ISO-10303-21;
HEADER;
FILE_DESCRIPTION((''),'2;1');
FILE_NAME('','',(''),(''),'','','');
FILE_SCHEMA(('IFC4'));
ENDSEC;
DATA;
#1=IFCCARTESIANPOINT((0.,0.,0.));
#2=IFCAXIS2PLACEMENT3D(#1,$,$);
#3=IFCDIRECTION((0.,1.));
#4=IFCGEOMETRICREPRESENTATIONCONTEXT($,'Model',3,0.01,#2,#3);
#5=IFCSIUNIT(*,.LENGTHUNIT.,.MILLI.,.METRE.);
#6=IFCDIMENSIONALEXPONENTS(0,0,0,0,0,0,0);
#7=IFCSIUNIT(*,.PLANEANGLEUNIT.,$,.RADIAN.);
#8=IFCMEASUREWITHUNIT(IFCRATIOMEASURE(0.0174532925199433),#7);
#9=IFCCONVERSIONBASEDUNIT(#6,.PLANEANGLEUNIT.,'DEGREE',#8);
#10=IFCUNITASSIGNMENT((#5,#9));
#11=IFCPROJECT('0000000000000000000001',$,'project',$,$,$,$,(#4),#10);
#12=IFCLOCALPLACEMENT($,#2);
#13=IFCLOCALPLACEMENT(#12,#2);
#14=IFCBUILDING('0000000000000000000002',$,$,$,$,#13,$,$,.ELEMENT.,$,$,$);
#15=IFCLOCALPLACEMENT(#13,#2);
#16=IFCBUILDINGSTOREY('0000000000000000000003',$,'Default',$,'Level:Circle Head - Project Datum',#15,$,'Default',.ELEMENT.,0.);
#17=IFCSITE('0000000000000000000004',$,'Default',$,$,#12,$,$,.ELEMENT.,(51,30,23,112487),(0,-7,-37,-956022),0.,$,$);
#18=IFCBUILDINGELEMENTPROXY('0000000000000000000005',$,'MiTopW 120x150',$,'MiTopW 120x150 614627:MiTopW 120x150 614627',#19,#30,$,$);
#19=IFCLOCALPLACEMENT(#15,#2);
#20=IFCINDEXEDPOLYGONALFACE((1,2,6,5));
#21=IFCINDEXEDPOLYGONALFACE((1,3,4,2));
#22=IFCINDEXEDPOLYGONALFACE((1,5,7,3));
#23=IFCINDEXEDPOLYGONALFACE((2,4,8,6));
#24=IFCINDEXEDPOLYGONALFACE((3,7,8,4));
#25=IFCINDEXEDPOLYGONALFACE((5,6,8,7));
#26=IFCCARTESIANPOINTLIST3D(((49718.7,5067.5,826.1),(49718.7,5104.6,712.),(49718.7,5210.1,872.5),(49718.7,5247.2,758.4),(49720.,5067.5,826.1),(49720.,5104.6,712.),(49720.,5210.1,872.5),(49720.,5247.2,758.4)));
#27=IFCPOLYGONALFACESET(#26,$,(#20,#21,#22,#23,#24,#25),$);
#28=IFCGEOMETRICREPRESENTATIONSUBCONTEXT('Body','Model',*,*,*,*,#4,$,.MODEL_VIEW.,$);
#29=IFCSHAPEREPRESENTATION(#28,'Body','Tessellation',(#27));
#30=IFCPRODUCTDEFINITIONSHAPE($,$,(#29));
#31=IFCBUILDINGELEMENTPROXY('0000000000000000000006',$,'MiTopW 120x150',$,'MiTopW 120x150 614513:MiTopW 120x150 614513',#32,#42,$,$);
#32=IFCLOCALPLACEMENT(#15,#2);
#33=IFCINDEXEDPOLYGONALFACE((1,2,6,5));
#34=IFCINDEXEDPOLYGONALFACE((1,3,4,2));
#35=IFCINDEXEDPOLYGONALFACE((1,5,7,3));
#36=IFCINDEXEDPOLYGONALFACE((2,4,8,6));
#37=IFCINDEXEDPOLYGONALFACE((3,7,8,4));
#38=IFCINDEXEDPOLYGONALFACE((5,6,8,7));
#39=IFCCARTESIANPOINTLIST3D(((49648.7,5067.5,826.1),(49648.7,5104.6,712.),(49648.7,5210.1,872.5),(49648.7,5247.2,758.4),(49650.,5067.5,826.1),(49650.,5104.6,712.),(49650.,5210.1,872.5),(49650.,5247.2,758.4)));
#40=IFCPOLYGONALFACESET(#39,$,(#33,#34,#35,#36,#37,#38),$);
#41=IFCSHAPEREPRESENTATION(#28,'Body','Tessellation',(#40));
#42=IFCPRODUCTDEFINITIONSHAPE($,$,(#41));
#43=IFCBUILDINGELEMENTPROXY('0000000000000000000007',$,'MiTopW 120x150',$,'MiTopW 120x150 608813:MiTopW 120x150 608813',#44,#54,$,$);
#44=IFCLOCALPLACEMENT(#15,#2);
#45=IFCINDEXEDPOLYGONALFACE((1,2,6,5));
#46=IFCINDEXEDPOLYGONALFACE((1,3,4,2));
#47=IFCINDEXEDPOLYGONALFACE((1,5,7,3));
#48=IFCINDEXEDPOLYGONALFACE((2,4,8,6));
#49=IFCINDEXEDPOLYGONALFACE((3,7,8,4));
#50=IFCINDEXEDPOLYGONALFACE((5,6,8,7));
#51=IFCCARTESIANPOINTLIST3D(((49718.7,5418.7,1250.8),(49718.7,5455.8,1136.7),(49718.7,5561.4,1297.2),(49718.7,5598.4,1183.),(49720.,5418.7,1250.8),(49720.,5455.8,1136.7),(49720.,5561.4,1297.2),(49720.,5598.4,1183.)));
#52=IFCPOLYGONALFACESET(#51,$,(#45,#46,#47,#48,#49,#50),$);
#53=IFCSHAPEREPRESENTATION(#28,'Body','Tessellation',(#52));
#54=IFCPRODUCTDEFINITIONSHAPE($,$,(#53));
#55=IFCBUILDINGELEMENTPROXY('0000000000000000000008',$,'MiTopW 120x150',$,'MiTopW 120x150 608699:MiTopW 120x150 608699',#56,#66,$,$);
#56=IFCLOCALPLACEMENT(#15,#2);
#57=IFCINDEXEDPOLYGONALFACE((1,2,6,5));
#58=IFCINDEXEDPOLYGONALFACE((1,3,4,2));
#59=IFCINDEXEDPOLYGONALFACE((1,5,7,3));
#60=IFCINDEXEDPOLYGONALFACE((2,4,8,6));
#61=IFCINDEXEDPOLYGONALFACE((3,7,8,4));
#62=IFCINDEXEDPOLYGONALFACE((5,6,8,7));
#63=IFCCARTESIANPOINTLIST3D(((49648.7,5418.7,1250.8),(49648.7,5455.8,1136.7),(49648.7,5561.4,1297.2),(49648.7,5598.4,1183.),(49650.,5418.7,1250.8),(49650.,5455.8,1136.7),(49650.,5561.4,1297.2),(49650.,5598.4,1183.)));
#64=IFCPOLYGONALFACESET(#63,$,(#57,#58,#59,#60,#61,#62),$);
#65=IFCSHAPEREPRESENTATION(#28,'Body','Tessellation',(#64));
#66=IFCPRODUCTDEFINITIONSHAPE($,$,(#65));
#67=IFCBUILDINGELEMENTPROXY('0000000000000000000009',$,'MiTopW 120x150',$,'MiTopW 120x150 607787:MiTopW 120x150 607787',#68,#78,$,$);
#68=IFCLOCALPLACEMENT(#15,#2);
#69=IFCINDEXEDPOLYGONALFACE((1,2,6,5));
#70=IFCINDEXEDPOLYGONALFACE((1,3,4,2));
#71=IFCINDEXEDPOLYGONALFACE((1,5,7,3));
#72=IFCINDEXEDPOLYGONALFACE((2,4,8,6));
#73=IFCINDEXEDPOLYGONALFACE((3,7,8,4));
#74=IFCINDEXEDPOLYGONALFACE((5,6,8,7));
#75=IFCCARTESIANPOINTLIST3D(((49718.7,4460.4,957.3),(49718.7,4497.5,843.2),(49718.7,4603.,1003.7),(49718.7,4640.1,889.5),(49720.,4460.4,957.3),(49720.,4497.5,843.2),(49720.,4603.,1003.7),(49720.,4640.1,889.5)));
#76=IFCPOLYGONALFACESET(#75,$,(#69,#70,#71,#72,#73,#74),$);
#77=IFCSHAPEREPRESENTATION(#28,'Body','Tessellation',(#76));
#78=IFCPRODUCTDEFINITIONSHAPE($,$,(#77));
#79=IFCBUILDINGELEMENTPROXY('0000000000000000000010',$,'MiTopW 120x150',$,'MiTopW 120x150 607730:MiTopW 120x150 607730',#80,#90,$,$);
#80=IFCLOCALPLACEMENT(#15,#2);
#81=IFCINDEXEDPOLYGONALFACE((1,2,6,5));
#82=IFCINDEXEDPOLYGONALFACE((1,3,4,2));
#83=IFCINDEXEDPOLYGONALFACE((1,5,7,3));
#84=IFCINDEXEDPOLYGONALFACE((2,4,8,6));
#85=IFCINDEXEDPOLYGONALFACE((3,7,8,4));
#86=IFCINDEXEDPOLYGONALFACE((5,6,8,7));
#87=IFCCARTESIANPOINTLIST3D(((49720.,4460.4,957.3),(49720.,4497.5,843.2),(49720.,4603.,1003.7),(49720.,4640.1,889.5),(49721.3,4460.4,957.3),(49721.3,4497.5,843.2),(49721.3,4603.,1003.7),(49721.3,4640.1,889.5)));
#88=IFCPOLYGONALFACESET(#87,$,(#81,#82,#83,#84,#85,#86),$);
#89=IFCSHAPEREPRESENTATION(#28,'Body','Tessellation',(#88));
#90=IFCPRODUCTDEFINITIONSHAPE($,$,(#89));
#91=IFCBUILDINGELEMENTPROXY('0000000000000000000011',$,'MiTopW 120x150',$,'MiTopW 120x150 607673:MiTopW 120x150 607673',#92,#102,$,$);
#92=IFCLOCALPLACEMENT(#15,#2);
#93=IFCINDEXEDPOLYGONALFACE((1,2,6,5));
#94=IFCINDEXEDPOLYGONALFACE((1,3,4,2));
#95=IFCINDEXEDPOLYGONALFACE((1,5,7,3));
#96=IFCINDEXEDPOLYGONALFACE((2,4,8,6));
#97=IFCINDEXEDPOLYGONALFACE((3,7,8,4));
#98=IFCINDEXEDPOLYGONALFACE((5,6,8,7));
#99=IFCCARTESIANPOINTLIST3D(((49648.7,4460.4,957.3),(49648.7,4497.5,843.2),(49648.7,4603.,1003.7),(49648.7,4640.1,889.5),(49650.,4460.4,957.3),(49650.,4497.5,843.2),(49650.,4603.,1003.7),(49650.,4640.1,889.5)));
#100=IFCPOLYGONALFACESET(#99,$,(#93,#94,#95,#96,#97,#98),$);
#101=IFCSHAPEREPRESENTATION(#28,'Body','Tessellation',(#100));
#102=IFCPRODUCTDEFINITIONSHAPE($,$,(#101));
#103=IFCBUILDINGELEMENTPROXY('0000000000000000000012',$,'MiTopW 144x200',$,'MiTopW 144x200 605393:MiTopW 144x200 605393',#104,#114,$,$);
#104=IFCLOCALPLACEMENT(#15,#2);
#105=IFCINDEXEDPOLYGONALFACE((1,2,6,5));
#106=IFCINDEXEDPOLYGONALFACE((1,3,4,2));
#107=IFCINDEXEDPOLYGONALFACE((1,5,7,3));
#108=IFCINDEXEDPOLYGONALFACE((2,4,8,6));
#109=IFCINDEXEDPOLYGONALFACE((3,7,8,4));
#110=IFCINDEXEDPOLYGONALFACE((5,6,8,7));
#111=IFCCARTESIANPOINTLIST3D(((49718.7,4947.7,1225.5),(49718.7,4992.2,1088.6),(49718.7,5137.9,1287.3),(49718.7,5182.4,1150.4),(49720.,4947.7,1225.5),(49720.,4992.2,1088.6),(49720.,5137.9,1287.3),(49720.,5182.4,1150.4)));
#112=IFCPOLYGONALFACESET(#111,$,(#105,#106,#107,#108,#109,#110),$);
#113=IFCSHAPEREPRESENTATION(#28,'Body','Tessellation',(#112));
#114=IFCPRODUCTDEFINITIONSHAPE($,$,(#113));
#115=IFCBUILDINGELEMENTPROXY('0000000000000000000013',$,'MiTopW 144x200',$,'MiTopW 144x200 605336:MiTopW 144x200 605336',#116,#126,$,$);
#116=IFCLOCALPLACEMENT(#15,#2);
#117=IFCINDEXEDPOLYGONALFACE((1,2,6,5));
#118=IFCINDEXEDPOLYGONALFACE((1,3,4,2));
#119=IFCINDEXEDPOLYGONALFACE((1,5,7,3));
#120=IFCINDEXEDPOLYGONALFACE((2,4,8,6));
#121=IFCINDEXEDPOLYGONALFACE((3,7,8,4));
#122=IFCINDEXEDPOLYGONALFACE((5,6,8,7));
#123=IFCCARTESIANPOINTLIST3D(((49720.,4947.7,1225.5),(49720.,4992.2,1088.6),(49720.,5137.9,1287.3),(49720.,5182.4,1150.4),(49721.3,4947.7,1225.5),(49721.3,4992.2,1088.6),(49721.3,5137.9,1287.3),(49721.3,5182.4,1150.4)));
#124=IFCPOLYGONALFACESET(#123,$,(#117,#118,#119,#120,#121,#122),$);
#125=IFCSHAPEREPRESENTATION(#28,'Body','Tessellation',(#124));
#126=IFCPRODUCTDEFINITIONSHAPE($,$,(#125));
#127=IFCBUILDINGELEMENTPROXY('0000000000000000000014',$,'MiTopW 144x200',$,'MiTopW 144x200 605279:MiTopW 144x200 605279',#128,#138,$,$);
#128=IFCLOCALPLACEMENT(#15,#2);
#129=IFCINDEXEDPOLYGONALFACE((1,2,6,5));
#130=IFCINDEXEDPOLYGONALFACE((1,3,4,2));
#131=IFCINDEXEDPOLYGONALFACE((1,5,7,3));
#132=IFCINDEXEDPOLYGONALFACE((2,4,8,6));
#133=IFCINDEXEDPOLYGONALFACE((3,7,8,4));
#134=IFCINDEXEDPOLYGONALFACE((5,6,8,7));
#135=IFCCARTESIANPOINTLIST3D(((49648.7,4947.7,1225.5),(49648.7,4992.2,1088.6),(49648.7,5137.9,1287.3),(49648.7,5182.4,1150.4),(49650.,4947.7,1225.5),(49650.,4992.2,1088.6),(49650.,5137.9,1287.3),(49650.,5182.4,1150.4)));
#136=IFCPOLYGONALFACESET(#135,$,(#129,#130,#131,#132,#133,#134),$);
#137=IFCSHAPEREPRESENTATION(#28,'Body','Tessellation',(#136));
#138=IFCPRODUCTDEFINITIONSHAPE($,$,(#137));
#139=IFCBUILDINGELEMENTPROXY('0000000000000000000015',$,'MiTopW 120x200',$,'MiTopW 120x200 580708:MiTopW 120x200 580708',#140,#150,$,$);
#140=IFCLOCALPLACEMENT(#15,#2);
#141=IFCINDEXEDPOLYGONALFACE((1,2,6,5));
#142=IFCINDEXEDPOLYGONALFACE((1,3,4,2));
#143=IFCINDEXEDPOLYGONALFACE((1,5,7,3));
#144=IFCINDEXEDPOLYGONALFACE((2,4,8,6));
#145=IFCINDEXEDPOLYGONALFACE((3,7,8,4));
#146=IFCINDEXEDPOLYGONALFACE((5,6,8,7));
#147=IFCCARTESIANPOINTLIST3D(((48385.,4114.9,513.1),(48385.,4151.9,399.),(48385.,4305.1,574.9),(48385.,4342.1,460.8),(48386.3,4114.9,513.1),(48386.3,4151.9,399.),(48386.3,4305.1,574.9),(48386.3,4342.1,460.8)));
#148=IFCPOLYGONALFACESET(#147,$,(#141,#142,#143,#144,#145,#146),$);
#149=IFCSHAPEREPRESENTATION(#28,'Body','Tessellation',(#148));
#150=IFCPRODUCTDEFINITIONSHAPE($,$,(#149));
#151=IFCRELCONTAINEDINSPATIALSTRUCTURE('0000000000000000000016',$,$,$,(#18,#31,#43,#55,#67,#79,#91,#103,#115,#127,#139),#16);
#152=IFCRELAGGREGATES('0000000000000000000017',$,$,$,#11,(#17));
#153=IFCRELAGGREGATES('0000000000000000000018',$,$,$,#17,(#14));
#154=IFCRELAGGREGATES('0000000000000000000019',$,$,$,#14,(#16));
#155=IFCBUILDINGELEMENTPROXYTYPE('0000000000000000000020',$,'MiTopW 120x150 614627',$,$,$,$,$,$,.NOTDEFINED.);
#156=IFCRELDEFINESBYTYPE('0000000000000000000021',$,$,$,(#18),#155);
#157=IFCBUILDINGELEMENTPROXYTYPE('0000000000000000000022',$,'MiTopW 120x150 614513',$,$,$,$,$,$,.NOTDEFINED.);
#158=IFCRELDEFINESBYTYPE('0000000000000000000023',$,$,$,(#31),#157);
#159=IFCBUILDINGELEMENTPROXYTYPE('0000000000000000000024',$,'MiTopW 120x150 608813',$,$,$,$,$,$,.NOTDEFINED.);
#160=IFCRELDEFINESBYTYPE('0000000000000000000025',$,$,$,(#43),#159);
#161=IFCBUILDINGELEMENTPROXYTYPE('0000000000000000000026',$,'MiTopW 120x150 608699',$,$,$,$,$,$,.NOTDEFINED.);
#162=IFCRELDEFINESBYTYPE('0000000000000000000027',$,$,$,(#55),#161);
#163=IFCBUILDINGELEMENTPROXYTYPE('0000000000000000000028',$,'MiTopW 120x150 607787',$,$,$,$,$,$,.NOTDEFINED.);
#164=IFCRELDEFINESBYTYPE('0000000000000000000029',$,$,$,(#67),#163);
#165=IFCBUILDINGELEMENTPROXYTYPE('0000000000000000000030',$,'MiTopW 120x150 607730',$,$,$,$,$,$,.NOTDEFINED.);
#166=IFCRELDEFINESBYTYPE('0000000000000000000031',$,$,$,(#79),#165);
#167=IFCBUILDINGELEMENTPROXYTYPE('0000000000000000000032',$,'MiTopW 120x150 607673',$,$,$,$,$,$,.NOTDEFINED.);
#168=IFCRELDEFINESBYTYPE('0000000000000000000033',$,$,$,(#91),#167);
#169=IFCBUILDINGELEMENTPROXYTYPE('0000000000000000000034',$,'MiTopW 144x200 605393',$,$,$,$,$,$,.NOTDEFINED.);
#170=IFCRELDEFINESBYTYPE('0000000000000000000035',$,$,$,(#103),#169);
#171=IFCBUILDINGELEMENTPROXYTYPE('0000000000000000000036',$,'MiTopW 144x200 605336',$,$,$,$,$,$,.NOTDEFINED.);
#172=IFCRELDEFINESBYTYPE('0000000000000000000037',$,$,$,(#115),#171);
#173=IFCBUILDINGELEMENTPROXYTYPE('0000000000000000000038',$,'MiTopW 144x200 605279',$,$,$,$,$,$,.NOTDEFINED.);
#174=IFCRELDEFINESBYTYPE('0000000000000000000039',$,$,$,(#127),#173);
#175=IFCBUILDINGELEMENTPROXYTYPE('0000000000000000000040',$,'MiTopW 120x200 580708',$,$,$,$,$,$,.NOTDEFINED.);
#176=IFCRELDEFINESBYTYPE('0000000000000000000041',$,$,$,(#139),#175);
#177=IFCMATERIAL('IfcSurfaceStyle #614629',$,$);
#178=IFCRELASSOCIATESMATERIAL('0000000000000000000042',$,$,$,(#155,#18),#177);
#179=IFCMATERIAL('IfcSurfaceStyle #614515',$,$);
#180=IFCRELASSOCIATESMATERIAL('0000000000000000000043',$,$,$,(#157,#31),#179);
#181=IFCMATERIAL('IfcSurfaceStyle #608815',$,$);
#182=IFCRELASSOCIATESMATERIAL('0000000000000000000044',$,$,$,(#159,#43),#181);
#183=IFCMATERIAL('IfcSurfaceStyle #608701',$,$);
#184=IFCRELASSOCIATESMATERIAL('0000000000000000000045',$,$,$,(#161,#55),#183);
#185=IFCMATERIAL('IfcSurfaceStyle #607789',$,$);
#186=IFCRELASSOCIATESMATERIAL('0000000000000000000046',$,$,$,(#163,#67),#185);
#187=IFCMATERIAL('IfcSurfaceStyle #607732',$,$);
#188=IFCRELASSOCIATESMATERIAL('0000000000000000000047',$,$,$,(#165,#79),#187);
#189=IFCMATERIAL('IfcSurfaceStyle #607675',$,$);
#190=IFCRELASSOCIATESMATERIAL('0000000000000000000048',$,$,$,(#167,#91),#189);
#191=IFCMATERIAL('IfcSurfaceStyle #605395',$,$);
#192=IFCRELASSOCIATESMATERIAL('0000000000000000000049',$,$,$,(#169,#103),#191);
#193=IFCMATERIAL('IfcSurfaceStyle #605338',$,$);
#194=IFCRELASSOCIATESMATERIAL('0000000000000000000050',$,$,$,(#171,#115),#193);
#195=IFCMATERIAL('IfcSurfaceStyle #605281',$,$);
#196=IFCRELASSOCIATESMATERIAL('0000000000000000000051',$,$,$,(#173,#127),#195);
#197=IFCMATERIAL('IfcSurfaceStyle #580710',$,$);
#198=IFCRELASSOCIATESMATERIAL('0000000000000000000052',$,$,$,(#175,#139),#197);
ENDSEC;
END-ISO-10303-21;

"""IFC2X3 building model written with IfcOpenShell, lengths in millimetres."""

from ifc_helpers import new_model, entity, si_unit, converted_unit, direction, frame, origin, place, context, subcontext, project, spatial, polyline, outline, extrude, source, transform, mapped, material, type_object, type_shapes, element, save


model = new_model("IFC2X3")

# Units and contexts
model_context = context("Model", 3, precision=0.01, world=origin(), true_north=direction((0.0, 1.0)))
body_context = subcontext(model_context, "Body", "Model", "MODEL_VIEW")
ifc_project = project(units=[si_unit("LENGTHUNIT", "METRE", prefix="MILLI"), converted_unit("PLANEANGLEUNIT", "DEGREE", entity("IfcRatioMeasure", 0.0174532925199433), si_unit("PLANEANGLEUNIT", "RADIAN"), dimensions=[0, 0, 0, 0, 0, 0, 0])], contexts=[model_context])

# Site, building, storey
site_placement = place(None, origin())
site = spatial("IfcSite", under=ifc_project, at=site_placement, Name="Default", CompositionType="ELEMENT", RefLatitude=(51, 30, 23, 112487), RefLongitude=(0, -7, -37, -956022), RefElevation=0.0)
building_placement = place(site_placement, origin())
building = spatial("IfcBuilding", under=site, at=building_placement, CompositionType="ELEMENT")
storey_placement = place(building_placement, origin())
storey = spatial("IfcBuildingStorey", under=building, at=storey_placement, Name="Default", ObjectType="Level:Circle Head - Project Datum", LongName="Default", CompositionType="ELEMENT", Elevation=0.0)

# Building element proxies
ifc_material_1 = material(Name="IfcSurfaceStyle #614629")
building_element_proxy_type_1 = type_object("IfcBuildingElementProxyType", Name="MiTopW 120x150 614627", PredefinedType="NOTDEFINED", material=ifc_material_1)
shared_shape_1 = source(origin(), body_context, "Body", "SweptSolid", [
    extrude(outline(polyline([(-75.0, -60.0), (75.0, -60.0), (75.0, 60.0), (-75.0, 60.0), (-75.0, -60.0)])), frame((75.0, 60.0, 0.0), z_axis=(0.0, 0.0, 1.0), x_axis=(-1.0, 0.0, 0.0)), (0.0, 0.0, 1.0), 1.3),
])
type_shapes(building_element_proxy_type_1, [shared_shape_1])
proxy_1_placement = place(building_placement, frame((49720.0, 5067.5, 826.1), z_axis=(-1.0, 0.0, 0.0), x_axis=(0.0, 0.951057, 0.309017)))
element("IfcBuildingElementProxy", 1, at=proxy_1_placement, inside=storey, type_object=building_element_proxy_type_1, material=ifc_material_1, Name="MiTopW 120x150", ObjectType="MiTopW 120x150 614627:MiTopW 120x150 614627", context=body_context, shape_type="MappedRepresentation", body=[
    mapped(shared_shape_1, transform((0.0, 0.0, 0.0), scale=1.0)),
])
ifc_material_2 = material(Name="IfcSurfaceStyle #614515")
building_element_proxy_type_2 = type_object("IfcBuildingElementProxyType", Name="MiTopW 120x150 614513", PredefinedType="NOTDEFINED", material=ifc_material_2)
shared_shape_2 = source(origin(), body_context, "Body", "SweptSolid", [
    extrude(outline(polyline([(-75.0, -60.0), (75.0, -60.0), (75.0, 60.0), (-75.0, 60.0), (-75.0, -60.0)])), frame((75.0, 60.0, 0.0), z_axis=(0.0, 0.0, 1.0), x_axis=(-1.0, 0.0, 0.0)), (0.0, 0.0, 1.0), 1.3),
])
type_shapes(building_element_proxy_type_2, [shared_shape_2])
proxy_2_placement = place(building_placement, frame((49650.0, 5067.5, 826.1), z_axis=(-1.0, 0.0, 0.0), x_axis=(0.0, 0.951057, 0.309017)))
element("IfcBuildingElementProxy", 2, at=proxy_2_placement, inside=storey, type_object=building_element_proxy_type_2, material=ifc_material_2, Name="MiTopW 120x150", ObjectType="MiTopW 120x150 614513:MiTopW 120x150 614513", context=body_context, shape_type="MappedRepresentation", body=[
    mapped(shared_shape_2, transform((0.0, 0.0, 0.0), scale=1.0)),
])
ifc_material_3 = material(Name="IfcSurfaceStyle #608815")
building_element_proxy_type_3 = type_object("IfcBuildingElementProxyType", Name="MiTopW 120x150 608813", PredefinedType="NOTDEFINED", material=ifc_material_3)
shared_shape_3 = source(origin(), body_context, "Body", "SweptSolid", [
    extrude(outline(polyline([(-75.0, -60.0), (75.0, -60.0), (75.0, 60.0), (-75.0, 60.0), (-75.0, -60.0)])), frame((75.0, 60.0, 0.0), z_axis=(0.0, 0.0, 1.0), x_axis=(-1.0, 0.0, 0.0)), (0.0, 0.0, 1.0), 1.3),
])
type_shapes(building_element_proxy_type_3, [shared_shape_3])
proxy_3_placement = place(building_placement, frame((49720.0, 5418.7, 1250.8), z_axis=(-1.0, 0.0, 0.0), x_axis=(0.0, 0.951057, 0.309017)))
element("IfcBuildingElementProxy", 3, at=proxy_3_placement, inside=storey, type_object=building_element_proxy_type_3, material=ifc_material_3, Name="MiTopW 120x150", ObjectType="MiTopW 120x150 608813:MiTopW 120x150 608813", context=body_context, shape_type="MappedRepresentation", body=[
    mapped(shared_shape_3, transform((0.0, 0.0, 0.0), scale=1.0)),
])
ifc_material_4 = material(Name="IfcSurfaceStyle #608701")
building_element_proxy_type_4 = type_object("IfcBuildingElementProxyType", Name="MiTopW 120x150 608699", PredefinedType="NOTDEFINED", material=ifc_material_4)
shared_shape_4 = source(origin(), body_context, "Body", "SweptSolid", [
    extrude(outline(polyline([(-75.0, -60.0), (75.0, -60.0), (75.0, 60.0), (-75.0, 60.0), (-75.0, -60.0)])), frame((75.0, 60.0, 0.0), z_axis=(0.0, 0.0, 1.0), x_axis=(-1.0, 0.0, 0.0)), (0.0, 0.0, 1.0), 1.3),
])
type_shapes(building_element_proxy_type_4, [shared_shape_4])
proxy_4_placement = place(building_placement, frame((49650.0, 5418.7, 1250.8), z_axis=(-1.0, 0.0, 0.0), x_axis=(0.0, 0.951057, 0.309017)))
element("IfcBuildingElementProxy", 4, at=proxy_4_placement, inside=storey, type_object=building_element_proxy_type_4, material=ifc_material_4, Name="MiTopW 120x150", ObjectType="MiTopW 120x150 608699:MiTopW 120x150 608699", context=body_context, shape_type="MappedRepresentation", body=[
    mapped(shared_shape_4, transform((0.0, 0.0, 0.0), scale=1.0)),
])
ifc_material_5 = material(Name="IfcSurfaceStyle #607789")
building_element_proxy_type_5 = type_object("IfcBuildingElementProxyType", Name="MiTopW 120x150 607787", PredefinedType="NOTDEFINED", material=ifc_material_5)
shared_shape_5 = source(origin(), body_context, "Body", "SweptSolid", [
    extrude(outline(polyline([(-75.0, -60.0), (75.0, -60.0), (75.0, 60.0), (-75.0, 60.0), (-75.0, -60.0)])), frame((75.0, 60.0, 0.0), z_axis=(0.0, 0.0, 1.0), x_axis=(-1.0, 0.0, 0.0)), (0.0, 0.0, 1.0), 1.3),
])
type_shapes(building_element_proxy_type_5, [shared_shape_5])
proxy_5_placement = place(building_placement, frame((49720.0, 4460.4, 957.3), z_axis=(-1.0, 0.0, 0.0), x_axis=(0.0, 0.951057, 0.309017)))
element("IfcBuildingElementProxy", 5, at=proxy_5_placement, inside=storey, type_object=building_element_proxy_type_5, material=ifc_material_5, Name="MiTopW 120x150", ObjectType="MiTopW 120x150 607787:MiTopW 120x150 607787", context=body_context, shape_type="MappedRepresentation", body=[
    mapped(shared_shape_5, transform((0.0, 0.0, 0.0), scale=1.0)),
])
ifc_material_6 = material(Name="IfcSurfaceStyle #607732")
building_element_proxy_type_6 = type_object("IfcBuildingElementProxyType", Name="MiTopW 120x150 607730", PredefinedType="NOTDEFINED", material=ifc_material_6)
shared_shape_6 = source(origin(), body_context, "Body", "SweptSolid", [
    extrude(outline(polyline([(-75.0, -60.0), (75.0, -60.0), (75.0, 60.0), (-75.0, 60.0), (-75.0, -60.0)])), frame((75.0, 60.0, 0.0), z_axis=(0.0, 0.0, 1.0), x_axis=(-1.0, 0.0, 0.0)), (0.0, 0.0, 1.0), 1.3),
])
type_shapes(building_element_proxy_type_6, [shared_shape_6])
proxy_6_placement = place(building_placement, frame((49721.3, 4460.4, 957.3), z_axis=(-1.0, 0.0, 0.0), x_axis=(0.0, 0.951057, 0.309017)))
element("IfcBuildingElementProxy", 6, at=proxy_6_placement, inside=storey, type_object=building_element_proxy_type_6, material=ifc_material_6, Name="MiTopW 120x150", ObjectType="MiTopW 120x150 607730:MiTopW 120x150 607730", context=body_context, shape_type="MappedRepresentation", body=[
    mapped(shared_shape_6, transform((0.0, 0.0, 0.0), scale=1.0)),
])
ifc_material_7 = material(Name="IfcSurfaceStyle #607675")
building_element_proxy_type_7 = type_object("IfcBuildingElementProxyType", Name="MiTopW 120x150 607673", PredefinedType="NOTDEFINED", material=ifc_material_7)
shared_shape_7 = source(origin(), body_context, "Body", "SweptSolid", [
    extrude(outline(polyline([(-75.0, -60.0), (75.0, -60.0), (75.0, 60.0), (-75.0, 60.0), (-75.0, -60.0)])), frame((75.0, 60.0, 0.0), z_axis=(0.0, 0.0, 1.0), x_axis=(-1.0, 0.0, 0.0)), (0.0, 0.0, 1.0), 1.3),
])
type_shapes(building_element_proxy_type_7, [shared_shape_7])
proxy_7_placement = place(building_placement, frame((49650.0, 4460.4, 957.3), z_axis=(-1.0, 0.0, 0.0), x_axis=(0.0, 0.951057, 0.309017)))
element("IfcBuildingElementProxy", 7, at=proxy_7_placement, inside=storey, type_object=building_element_proxy_type_7, material=ifc_material_7, Name="MiTopW 120x150", ObjectType="MiTopW 120x150 607673:MiTopW 120x150 607673", context=body_context, shape_type="MappedRepresentation", body=[
    mapped(shared_shape_7, transform((0.0, 0.0, 0.0), scale=1.0)),
])
ifc_material_8 = material(Name="IfcSurfaceStyle #605395")
building_element_proxy_type_8 = type_object("IfcBuildingElementProxyType", Name="MiTopW 144x200 605393", PredefinedType="NOTDEFINED", material=ifc_material_8)
shared_shape_8 = source(origin(), body_context, "Body", "SweptSolid", [
    extrude(outline(polyline([(-100.0, -72.0), (100.0, -72.0), (100.0, 72.0), (-100.0, 72.0), (-100.0, -72.0)])), frame((100.0, 72.0, 0.0), z_axis=(0.0, 0.0, 1.0), x_axis=(-1.0, 0.0, 0.0)), (0.0, 0.0, 1.0), 1.3),
])
type_shapes(building_element_proxy_type_8, [shared_shape_8])
proxy_8_placement = place(building_placement, frame((49720.0, 4947.7, 1225.5), z_axis=(-1.0, 0.0, 0.0), x_axis=(0.0, 0.951057, 0.309017)))
element("IfcBuildingElementProxy", 8, at=proxy_8_placement, inside=storey, type_object=building_element_proxy_type_8, material=ifc_material_8, Name="MiTopW 144x200", ObjectType="MiTopW 144x200 605393:MiTopW 144x200 605393", context=body_context, shape_type="MappedRepresentation", body=[
    mapped(shared_shape_8, transform((0.0, 0.0, 0.0), scale=1.0)),
])
ifc_material_9 = material(Name="IfcSurfaceStyle #605338")
building_element_proxy_type_9 = type_object("IfcBuildingElementProxyType", Name="MiTopW 144x200 605336", PredefinedType="NOTDEFINED", material=ifc_material_9)
shared_shape_9 = source(origin(), body_context, "Body", "SweptSolid", [
    extrude(outline(polyline([(-100.0, -72.0), (100.0, -72.0), (100.0, 72.0), (-100.0, 72.0), (-100.0, -72.0)])), frame((100.0, 72.0, 0.0), z_axis=(0.0, 0.0, 1.0), x_axis=(-1.0, 0.0, 0.0)), (0.0, 0.0, 1.0), 1.3),
])
type_shapes(building_element_proxy_type_9, [shared_shape_9])
proxy_9_placement = place(building_placement, frame((49721.3, 4947.7, 1225.5), z_axis=(-1.0, 0.0, 0.0), x_axis=(0.0, 0.951057, 0.309017)))
element("IfcBuildingElementProxy", 9, at=proxy_9_placement, inside=storey, type_object=building_element_proxy_type_9, material=ifc_material_9, Name="MiTopW 144x200", ObjectType="MiTopW 144x200 605336:MiTopW 144x200 605336", context=body_context, shape_type="MappedRepresentation", body=[
    mapped(shared_shape_9, transform((0.0, 0.0, 0.0), scale=1.0)),
])
ifc_material_10 = material(Name="IfcSurfaceStyle #605281")
building_element_proxy_type_10 = type_object("IfcBuildingElementProxyType", Name="MiTopW 144x200 605279", PredefinedType="NOTDEFINED", material=ifc_material_10)
shared_shape_10 = source(origin(), body_context, "Body", "SweptSolid", [
    extrude(outline(polyline([(-100.0, -72.0), (100.0, -72.0), (100.0, 72.0), (-100.0, 72.0), (-100.0, -72.0)])), frame((100.0, 72.0, 0.0), z_axis=(0.0, 0.0, 1.0), x_axis=(-1.0, 0.0, 0.0)), (0.0, 0.0, 1.0), 1.3),
])
type_shapes(building_element_proxy_type_10, [shared_shape_10])
proxy_10_placement = place(building_placement, frame((49650.0, 4947.7, 1225.5), z_axis=(-1.0, 0.0, 0.0), x_axis=(0.0, 0.951057, 0.309017)))
element("IfcBuildingElementProxy", 10, at=proxy_10_placement, inside=storey, type_object=building_element_proxy_type_10, material=ifc_material_10, Name="MiTopW 144x200", ObjectType="MiTopW 144x200 605279:MiTopW 144x200 605279", context=body_context, shape_type="MappedRepresentation", body=[
    mapped(shared_shape_10, transform((0.0, 0.0, 0.0), scale=1.0)),
])
ifc_material_11 = material(Name="IfcSurfaceStyle #580710")
building_element_proxy_type_11 = type_object("IfcBuildingElementProxyType", Name="MiTopW 120x200 580708", PredefinedType="NOTDEFINED", material=ifc_material_11)
shared_shape_11 = source(origin(), body_context, "Body", "SweptSolid", [
    extrude(outline(polyline([(-100.0, -60.0), (100.0, -60.0), (100.0, 60.0), (-100.0, 60.0), (-100.0, -60.0)])), frame((100.0, 60.0, 0.0), z_axis=(0.0, 0.0, 1.0), x_axis=(-1.0, 0.0, 0.0)), (0.0, 0.0, 1.0), 1.3),
])
type_shapes(building_element_proxy_type_11, [shared_shape_11])
proxy_11_placement = place(building_placement, frame((48386.3, 4114.9, 513.1), z_axis=(-1.0, 0.0, 0.0), x_axis=(0.0, 0.951057, 0.309017)))
element("IfcBuildingElementProxy", 11, at=proxy_11_placement, inside=storey, type_object=building_element_proxy_type_11, material=ifc_material_11, Name="MiTopW 120x200", ObjectType="MiTopW 120x200 580708:MiTopW 120x200 580708", context=body_context, shape_type="MappedRepresentation", body=[
    mapped(shared_shape_11, transform((0.0, 0.0, 0.0), scale=1.0)),
])

save(model, "model.ifc")
